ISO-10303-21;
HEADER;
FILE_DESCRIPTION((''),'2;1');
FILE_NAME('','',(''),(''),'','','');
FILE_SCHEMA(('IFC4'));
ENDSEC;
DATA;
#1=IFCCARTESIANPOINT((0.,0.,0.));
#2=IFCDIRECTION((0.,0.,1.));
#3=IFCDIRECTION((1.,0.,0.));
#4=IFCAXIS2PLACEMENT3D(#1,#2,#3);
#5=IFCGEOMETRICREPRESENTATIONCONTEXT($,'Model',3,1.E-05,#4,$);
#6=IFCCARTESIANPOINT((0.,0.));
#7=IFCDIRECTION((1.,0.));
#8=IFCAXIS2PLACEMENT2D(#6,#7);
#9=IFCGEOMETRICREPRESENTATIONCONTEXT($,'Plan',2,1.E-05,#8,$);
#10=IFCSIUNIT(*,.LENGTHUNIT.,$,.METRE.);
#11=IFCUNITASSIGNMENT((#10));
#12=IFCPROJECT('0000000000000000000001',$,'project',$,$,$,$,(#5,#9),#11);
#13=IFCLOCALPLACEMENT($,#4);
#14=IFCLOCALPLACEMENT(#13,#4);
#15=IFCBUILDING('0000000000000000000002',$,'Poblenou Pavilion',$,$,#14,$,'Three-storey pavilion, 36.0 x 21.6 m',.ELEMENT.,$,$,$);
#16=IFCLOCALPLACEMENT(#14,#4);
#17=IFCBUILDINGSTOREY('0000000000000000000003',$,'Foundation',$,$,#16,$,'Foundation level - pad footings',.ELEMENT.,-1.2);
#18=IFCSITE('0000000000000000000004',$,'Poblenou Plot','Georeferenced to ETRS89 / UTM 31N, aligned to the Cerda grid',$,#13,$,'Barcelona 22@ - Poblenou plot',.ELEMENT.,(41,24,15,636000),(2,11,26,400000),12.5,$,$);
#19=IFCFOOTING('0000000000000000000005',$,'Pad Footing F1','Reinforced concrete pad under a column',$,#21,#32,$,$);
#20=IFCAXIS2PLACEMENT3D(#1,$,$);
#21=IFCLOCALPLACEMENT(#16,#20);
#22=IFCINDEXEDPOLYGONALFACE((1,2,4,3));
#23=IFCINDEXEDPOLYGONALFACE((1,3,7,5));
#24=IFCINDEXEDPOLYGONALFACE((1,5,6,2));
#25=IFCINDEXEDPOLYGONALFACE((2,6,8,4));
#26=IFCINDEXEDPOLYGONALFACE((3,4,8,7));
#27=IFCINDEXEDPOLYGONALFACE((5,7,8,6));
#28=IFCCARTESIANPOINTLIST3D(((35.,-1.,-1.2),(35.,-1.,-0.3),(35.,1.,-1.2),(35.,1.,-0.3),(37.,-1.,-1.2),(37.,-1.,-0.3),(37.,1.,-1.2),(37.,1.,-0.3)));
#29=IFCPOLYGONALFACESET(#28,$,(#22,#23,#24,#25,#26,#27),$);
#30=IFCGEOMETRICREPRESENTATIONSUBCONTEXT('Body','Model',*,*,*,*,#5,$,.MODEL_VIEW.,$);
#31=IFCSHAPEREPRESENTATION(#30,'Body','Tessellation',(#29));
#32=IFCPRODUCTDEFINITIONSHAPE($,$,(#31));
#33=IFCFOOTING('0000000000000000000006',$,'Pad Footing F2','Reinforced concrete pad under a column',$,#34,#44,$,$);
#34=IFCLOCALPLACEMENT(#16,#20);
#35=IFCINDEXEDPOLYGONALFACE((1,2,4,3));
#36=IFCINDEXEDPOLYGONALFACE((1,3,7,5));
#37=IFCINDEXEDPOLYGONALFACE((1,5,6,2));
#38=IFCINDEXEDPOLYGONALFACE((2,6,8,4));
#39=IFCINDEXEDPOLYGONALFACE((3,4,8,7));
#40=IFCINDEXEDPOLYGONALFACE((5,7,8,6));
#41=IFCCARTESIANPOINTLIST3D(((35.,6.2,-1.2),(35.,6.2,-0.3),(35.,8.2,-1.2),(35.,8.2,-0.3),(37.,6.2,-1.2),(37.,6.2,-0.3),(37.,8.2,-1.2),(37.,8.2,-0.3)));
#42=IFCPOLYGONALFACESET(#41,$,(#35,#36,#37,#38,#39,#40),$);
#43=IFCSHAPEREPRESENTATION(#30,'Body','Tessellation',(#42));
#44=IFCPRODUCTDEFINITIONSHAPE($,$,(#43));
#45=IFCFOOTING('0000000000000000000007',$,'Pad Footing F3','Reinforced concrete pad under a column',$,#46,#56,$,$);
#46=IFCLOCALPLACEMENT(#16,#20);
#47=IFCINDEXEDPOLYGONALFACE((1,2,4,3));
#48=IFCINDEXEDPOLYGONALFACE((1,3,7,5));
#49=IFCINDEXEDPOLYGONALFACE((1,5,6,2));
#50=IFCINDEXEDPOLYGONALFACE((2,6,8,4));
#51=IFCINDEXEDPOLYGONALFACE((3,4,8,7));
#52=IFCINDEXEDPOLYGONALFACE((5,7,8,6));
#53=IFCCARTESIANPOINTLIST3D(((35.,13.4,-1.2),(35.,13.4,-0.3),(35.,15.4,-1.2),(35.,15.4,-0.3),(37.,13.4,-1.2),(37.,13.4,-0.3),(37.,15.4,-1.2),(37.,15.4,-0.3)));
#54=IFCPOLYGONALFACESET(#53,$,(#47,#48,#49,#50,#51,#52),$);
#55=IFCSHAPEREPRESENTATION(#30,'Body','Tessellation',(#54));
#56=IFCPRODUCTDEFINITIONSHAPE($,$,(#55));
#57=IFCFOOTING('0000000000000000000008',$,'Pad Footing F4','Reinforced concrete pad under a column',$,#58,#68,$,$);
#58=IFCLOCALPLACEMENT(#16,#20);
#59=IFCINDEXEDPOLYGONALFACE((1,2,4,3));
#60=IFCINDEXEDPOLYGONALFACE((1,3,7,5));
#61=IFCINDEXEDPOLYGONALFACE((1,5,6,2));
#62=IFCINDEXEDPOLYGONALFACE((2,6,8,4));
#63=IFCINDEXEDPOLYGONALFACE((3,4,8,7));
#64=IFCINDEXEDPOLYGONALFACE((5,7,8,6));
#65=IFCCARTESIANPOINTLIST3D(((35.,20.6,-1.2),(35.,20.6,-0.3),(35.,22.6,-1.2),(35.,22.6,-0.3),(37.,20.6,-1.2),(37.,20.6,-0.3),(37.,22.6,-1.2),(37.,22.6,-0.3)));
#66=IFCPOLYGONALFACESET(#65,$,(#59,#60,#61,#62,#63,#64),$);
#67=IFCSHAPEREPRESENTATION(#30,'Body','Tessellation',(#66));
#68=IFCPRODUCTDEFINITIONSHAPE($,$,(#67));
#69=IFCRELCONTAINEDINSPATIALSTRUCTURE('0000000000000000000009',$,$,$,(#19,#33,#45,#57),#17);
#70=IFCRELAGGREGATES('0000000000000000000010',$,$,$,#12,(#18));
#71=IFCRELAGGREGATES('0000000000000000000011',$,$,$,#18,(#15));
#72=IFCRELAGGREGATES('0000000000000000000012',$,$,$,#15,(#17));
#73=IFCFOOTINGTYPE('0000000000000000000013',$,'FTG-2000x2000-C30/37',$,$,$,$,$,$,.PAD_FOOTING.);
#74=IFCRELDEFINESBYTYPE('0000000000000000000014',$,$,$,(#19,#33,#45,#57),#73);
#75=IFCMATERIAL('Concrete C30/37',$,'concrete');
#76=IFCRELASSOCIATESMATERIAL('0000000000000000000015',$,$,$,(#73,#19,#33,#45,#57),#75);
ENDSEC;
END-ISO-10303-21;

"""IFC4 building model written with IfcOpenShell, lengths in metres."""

from ifc_helpers import new_model, si_unit, frame, origin_with_axes, origin_2d_with_axis, place, context, subcontext, project, spatial, line, indexed_curve, outline, extrude, material, type_object, element, save


model = new_model("IFC4")

# Units and contexts
model_context = context("Model", 3, precision=1e-05, world=origin_with_axes())
plan_context = context("Plan", 2, precision=1e-05, world=origin_2d_with_axis())
body_context = subcontext(model_context, "Body", "Model", "MODEL_VIEW")
ifc_project = project(units=[si_unit("LENGTHUNIT", "METRE")], contexts=[model_context, plan_context])

# Site, building, storey
site_placement = place(None, origin_with_axes())
site = spatial("IfcSite", under=ifc_project, at=site_placement, Name="Poblenou Plot", Description="Georeferenced to ETRS89 / UTM 31N, aligned to the Cerda grid", LongName="Barcelona 22@ - Poblenou plot", CompositionType="ELEMENT", RefLatitude=(41, 24, 15, 636000), RefLongitude=(2, 11, 26, 400000), RefElevation=12.5)
building_placement = place(site_placement, origin_with_axes())
building = spatial("IfcBuilding", under=site, at=building_placement, Name="Poblenou Pavilion", LongName="Three-storey pavilion, 36.0 x 21.6 m", CompositionType="ELEMENT")
storey_placement = place(building_placement, origin_with_axes())
storey = spatial("IfcBuildingStorey", under=building, at=storey_placement, Name="Foundation", LongName="Foundation level - pad footings", CompositionType="ELEMENT", Elevation=-1.2)

# Footings
ifc_material = material(Name="Concrete C30/37", Category="concrete")
footing_type = type_object("IfcFootingType", Name="FTG-2000x2000-C30/37", PredefinedType="PAD_FOOTING", material=ifc_material)
for number, where, z_axis, x_axis, name in (
    (1, (35.0, -1.0, -1.2), (0.0, 0.0, 1.0), (1.0, 0.0, 0.0), "Pad Footing F1"),
    (2, (35.0, 6.2, -1.2), (0.0, 0.0, 1.0), (1.0, 0.0, 0.0), "Pad Footing F2"),
    (3, (35.0, 13.4, -1.2), (0.0, 0.0, 1.0), (1.0, 0.0, 0.0), "Pad Footing F3"),
    (4, (35.0, 20.6, -1.2), (0.0, 0.0, 1.0), (1.0, 0.0, 0.0), "Pad Footing F4"),
):
    element("IfcFooting", number, at=place(storey_placement, frame(where, z_axis=z_axis, x_axis=x_axis)), inside=storey, type_object=footing_type, material=ifc_material, Name=name, Description="Reinforced concrete pad under a column", context=body_context, shape_type="SweptSolid", body=[
        extrude(outline(indexed_curve([(0.0, 0.0), (2.0, 0.0), (2.0, 2.0), (0.0, 2.0)], segments=[line(1, 2, 3, 4, 1)])), origin_with_axes(), (0.0, 0.0, 1.0), 0.9),
    ])

save(model, "model.ifc")
